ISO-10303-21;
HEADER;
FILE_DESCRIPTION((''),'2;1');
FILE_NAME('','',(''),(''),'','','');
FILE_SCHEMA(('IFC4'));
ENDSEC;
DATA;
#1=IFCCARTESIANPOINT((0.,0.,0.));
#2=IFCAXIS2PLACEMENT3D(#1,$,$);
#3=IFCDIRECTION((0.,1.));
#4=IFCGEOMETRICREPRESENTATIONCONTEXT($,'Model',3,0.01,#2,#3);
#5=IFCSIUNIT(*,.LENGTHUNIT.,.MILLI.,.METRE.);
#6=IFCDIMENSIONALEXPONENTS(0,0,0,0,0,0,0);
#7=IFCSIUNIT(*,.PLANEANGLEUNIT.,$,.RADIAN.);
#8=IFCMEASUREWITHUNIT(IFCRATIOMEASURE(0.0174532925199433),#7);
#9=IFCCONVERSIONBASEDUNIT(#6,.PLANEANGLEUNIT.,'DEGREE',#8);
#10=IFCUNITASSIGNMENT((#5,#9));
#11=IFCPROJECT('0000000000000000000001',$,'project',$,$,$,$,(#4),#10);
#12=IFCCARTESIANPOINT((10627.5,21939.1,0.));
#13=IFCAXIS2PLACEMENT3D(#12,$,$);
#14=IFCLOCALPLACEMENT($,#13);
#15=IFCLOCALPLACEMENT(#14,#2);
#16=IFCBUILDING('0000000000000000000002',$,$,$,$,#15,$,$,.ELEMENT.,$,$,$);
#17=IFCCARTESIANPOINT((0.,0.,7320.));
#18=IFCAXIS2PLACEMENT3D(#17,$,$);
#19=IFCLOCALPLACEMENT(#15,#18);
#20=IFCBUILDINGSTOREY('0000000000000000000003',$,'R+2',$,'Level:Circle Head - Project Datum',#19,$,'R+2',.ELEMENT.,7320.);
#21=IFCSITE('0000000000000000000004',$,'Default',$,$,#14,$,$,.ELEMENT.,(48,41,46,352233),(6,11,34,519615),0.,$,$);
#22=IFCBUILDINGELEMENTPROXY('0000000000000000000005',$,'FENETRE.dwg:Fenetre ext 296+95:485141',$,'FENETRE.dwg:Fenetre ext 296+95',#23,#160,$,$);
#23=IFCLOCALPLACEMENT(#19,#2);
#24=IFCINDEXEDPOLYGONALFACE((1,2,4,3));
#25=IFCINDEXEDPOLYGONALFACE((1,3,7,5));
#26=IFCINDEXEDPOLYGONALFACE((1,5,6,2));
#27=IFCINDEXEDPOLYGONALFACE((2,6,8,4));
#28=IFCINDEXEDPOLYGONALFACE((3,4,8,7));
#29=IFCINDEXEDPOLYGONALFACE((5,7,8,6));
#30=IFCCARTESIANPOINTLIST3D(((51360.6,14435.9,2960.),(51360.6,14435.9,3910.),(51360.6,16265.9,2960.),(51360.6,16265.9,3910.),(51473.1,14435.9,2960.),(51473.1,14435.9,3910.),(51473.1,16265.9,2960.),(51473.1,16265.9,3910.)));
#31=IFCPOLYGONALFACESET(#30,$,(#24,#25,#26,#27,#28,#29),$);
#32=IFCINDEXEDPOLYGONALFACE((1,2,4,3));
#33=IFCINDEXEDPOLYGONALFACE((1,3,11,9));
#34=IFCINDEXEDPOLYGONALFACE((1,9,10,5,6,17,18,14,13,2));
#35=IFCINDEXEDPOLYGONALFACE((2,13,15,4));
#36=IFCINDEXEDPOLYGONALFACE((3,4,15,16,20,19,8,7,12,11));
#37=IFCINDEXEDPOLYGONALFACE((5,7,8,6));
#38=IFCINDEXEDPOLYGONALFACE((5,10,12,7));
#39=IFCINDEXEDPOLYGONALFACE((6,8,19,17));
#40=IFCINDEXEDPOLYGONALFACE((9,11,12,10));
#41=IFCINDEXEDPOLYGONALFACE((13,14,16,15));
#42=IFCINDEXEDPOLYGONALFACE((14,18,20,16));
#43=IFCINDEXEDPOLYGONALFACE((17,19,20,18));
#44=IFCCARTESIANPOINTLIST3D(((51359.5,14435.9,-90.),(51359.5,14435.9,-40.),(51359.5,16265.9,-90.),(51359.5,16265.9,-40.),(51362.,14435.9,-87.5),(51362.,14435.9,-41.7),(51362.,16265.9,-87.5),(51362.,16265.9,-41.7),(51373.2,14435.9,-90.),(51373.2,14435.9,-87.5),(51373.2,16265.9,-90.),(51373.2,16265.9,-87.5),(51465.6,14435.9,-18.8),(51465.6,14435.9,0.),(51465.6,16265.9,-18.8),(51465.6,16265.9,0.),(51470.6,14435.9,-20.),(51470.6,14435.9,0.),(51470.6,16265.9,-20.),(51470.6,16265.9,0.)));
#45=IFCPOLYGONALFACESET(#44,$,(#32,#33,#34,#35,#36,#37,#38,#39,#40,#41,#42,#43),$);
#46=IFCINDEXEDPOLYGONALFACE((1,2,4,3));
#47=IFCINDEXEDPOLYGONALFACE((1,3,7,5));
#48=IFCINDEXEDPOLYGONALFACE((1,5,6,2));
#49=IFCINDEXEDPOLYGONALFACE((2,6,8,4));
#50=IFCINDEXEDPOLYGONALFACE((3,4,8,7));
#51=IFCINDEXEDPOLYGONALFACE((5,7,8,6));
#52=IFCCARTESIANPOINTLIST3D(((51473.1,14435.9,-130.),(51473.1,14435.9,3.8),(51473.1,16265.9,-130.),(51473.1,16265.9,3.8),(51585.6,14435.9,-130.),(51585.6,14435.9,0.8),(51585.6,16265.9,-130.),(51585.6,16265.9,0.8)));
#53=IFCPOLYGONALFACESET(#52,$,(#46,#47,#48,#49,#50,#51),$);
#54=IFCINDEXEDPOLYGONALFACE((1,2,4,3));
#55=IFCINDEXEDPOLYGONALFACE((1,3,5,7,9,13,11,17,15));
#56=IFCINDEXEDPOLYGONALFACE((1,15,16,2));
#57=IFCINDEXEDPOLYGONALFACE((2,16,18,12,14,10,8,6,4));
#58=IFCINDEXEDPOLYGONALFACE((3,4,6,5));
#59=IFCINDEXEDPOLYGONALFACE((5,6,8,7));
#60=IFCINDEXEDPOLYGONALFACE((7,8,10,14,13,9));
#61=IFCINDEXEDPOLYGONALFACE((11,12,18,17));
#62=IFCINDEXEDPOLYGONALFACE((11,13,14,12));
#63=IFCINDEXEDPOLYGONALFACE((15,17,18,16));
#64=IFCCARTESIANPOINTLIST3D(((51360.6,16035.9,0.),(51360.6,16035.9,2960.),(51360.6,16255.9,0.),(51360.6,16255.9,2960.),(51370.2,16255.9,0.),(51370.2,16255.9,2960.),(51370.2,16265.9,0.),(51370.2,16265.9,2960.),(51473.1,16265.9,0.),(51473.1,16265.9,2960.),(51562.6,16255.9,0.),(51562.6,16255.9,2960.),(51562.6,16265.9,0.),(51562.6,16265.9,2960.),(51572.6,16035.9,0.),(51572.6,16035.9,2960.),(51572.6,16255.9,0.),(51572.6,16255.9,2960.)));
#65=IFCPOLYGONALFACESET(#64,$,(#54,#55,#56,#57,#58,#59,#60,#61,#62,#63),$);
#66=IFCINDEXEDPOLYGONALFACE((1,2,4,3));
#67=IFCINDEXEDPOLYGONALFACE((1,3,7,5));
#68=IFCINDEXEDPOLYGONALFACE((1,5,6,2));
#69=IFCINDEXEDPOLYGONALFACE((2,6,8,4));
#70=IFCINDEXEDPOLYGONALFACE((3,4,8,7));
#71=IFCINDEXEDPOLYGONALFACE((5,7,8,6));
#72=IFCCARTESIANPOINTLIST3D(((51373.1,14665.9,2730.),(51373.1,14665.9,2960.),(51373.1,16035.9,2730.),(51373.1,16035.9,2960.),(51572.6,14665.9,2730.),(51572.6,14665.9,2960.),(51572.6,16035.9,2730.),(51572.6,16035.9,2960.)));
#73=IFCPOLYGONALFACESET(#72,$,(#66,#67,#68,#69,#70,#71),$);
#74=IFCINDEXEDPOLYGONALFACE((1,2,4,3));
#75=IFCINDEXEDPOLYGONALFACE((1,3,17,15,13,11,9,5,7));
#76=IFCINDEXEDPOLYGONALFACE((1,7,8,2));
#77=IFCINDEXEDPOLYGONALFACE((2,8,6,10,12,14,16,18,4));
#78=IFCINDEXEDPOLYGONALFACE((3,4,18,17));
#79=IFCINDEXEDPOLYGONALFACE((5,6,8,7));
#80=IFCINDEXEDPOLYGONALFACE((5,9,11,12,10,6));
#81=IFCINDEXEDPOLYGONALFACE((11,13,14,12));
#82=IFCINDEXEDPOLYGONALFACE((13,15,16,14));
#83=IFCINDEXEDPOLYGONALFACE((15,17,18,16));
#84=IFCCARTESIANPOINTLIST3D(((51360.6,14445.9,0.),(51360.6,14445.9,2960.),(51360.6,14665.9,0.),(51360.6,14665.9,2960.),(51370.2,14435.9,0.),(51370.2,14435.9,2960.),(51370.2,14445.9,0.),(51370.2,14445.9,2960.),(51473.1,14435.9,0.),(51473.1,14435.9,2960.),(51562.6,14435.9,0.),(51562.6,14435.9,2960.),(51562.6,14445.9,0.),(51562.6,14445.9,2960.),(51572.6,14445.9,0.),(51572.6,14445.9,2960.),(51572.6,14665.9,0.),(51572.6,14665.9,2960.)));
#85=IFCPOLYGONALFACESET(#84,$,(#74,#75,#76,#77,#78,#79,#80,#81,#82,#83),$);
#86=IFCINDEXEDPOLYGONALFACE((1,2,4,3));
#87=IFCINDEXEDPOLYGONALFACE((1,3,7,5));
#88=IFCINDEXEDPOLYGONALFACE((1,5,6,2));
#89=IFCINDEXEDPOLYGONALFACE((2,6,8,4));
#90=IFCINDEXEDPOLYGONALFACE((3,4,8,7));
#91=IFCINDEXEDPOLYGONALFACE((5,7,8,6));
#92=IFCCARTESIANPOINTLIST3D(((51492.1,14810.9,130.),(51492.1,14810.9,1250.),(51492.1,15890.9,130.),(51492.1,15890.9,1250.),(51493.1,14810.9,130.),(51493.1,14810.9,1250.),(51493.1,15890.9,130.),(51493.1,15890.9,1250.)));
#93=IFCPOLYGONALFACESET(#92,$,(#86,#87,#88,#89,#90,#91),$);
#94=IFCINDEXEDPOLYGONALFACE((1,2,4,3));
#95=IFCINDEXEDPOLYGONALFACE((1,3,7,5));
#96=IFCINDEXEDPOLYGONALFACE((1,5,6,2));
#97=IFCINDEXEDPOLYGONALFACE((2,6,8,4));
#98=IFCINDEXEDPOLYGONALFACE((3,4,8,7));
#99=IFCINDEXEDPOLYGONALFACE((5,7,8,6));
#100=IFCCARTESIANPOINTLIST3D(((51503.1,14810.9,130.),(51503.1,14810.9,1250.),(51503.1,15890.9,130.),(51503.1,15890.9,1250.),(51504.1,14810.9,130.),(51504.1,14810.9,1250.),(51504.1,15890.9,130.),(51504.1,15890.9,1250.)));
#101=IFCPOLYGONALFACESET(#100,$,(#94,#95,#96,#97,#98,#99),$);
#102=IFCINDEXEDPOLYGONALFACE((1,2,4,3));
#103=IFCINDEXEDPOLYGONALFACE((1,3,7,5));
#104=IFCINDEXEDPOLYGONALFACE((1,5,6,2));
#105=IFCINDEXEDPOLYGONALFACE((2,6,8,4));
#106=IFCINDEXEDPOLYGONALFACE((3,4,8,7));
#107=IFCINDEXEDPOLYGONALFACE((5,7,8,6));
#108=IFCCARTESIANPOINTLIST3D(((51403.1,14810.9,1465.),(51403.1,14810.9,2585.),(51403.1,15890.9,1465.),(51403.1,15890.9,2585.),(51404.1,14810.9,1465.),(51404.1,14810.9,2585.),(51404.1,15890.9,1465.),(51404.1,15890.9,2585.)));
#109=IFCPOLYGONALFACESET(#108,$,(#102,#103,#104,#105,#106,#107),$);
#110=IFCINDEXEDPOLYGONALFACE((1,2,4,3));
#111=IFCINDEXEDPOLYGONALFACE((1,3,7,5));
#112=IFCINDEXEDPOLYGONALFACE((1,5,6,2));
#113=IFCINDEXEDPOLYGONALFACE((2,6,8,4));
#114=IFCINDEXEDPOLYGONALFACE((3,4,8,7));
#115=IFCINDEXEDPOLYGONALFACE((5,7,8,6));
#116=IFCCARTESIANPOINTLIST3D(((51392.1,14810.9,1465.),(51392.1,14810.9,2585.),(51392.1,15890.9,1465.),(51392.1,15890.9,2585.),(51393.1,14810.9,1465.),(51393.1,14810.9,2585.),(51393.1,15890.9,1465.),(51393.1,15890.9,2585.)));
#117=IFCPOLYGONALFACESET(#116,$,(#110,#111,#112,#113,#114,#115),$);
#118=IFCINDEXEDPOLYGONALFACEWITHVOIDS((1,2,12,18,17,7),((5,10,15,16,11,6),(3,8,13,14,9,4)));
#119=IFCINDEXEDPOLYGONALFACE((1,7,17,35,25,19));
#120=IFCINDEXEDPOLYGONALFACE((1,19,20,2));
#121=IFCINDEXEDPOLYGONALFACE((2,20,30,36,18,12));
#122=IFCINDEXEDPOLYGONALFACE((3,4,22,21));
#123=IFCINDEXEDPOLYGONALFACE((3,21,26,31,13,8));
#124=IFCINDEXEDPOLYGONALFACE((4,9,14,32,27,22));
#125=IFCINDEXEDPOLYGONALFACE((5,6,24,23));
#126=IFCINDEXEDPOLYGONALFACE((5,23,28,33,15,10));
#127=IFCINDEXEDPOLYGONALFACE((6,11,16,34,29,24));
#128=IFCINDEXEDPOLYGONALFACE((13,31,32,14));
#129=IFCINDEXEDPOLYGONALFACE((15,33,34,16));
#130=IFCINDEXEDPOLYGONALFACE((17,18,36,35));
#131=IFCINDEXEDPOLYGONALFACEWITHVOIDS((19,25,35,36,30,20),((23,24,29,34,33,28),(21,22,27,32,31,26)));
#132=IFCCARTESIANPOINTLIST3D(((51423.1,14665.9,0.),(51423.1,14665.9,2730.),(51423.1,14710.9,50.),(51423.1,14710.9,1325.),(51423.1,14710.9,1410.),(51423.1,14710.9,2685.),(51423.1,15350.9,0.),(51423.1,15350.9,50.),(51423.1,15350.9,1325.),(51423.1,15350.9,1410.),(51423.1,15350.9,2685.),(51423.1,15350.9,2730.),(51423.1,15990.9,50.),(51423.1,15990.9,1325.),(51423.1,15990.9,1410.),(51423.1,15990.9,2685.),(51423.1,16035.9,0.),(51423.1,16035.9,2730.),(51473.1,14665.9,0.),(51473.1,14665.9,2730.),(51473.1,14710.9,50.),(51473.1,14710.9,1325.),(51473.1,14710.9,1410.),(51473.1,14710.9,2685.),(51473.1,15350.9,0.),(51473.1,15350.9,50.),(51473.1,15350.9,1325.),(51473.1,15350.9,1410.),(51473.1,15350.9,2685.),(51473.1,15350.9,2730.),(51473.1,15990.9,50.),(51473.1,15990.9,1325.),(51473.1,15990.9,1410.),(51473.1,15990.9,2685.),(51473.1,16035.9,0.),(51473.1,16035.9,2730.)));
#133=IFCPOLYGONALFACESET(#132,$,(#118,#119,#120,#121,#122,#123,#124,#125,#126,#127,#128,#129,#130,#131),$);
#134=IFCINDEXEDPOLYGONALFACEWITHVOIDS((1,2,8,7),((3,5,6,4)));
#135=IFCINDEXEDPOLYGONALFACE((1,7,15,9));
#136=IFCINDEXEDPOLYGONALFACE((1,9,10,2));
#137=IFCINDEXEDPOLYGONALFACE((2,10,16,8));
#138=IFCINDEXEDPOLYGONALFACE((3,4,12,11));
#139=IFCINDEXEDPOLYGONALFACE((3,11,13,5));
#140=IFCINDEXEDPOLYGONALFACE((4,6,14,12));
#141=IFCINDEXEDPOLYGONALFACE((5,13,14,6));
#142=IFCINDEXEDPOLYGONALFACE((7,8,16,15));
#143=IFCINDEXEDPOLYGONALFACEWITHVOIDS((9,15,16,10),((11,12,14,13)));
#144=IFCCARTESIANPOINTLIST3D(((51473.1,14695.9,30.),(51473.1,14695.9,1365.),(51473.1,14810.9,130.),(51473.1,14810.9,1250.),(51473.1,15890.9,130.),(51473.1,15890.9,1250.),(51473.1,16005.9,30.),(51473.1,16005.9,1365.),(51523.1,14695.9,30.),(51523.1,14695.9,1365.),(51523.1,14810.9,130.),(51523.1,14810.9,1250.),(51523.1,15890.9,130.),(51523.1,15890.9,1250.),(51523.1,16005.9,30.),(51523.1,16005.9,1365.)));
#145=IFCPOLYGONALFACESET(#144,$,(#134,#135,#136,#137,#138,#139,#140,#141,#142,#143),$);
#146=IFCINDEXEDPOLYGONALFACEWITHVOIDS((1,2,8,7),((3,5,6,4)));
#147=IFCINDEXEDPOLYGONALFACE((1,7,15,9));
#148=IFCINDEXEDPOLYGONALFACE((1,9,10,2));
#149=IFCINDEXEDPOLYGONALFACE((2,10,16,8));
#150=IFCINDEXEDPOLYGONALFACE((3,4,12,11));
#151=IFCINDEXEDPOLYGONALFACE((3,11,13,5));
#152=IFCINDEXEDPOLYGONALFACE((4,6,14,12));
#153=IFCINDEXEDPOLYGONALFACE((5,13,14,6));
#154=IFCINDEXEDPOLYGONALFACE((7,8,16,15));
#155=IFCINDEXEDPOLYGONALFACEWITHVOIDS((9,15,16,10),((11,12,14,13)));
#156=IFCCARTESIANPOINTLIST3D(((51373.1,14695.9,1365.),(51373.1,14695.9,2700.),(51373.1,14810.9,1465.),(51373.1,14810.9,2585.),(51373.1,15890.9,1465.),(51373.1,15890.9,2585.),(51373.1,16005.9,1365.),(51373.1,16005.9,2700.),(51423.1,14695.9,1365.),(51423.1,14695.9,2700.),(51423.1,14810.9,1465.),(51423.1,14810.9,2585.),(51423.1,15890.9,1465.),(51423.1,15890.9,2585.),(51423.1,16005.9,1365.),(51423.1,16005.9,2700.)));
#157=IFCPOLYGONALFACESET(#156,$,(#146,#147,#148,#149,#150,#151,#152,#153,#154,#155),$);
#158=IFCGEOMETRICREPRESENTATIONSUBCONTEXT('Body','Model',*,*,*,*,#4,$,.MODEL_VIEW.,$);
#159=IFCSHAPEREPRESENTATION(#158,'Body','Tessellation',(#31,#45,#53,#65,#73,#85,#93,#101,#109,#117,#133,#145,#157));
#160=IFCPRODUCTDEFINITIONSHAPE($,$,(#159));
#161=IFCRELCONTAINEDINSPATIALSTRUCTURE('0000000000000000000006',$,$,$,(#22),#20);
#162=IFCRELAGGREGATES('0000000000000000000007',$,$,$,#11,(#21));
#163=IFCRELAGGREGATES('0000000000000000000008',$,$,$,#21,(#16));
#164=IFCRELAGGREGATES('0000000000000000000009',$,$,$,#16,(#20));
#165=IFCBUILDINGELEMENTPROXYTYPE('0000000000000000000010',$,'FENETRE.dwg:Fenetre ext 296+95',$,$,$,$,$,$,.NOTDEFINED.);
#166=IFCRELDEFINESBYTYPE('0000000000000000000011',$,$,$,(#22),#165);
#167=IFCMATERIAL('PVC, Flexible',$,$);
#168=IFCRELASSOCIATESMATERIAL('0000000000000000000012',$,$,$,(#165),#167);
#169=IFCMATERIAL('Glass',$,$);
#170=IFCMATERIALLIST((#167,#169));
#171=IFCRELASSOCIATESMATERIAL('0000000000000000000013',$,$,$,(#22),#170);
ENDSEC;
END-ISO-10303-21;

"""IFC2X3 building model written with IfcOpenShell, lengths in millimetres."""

from ifc_helpers import new_model, entity, si_unit, converted_unit, direction, frame, frame_2d, origin, origin_2d_with_axis, place, context, subcontext, project, spatial, polyline, rectangle, outline, extrude, source, transform, mapped, material, material_list, type_object, type_shapes, element, save


model = new_model("IFC2X3")

# Units and contexts
model_context = context("Model", 3, precision=0.01, world=origin(), true_north=direction((0.0, 1.0)))
body_context = subcontext(model_context, "Body", "Model", "MODEL_VIEW")
ifc_project = project(units=[si_unit("LENGTHUNIT", "METRE", prefix="MILLI"), converted_unit("PLANEANGLEUNIT", "DEGREE", entity("IfcRatioMeasure", 0.0174532925199433), si_unit("PLANEANGLEUNIT", "RADIAN"), dimensions=[0, 0, 0, 0, 0, 0, 0])], contexts=[model_context])

# Site, building, storey
site_placement = place(None, frame((10627.5, 21939.1, 0.0)))
site = spatial("IfcSite", under=ifc_project, at=site_placement, Name="Default", CompositionType="ELEMENT", RefLatitude=(48, 41, 46, 352233), RefLongitude=(6, 11, 34, 519615), RefElevation=0.0)
building_placement = place(site_placement, origin())
building = spatial("IfcBuilding", under=site, at=building_placement, CompositionType="ELEMENT")
storey_placement = place(building_placement, frame((0.0, 0.0, 7320.0)))
storey = spatial("IfcBuildingStorey", under=building, at=storey_placement, Name="R+2", ObjectType="Level:Circle Head - Project Datum", LongName="R+2", CompositionType="ELEMENT", Elevation=7320.0)

# Building element proxy
ifc_material_1 = material(Name="PVC, Flexible")
ifc_material_2 = material(Name="Glass")
ifc_material_list_1 = material_list([ifc_material_1, ifc_material_2])
building_element_proxy_type_1 = type_object("IfcBuildingElementProxyType", Name="FENETRE.dwg:Fenetre ext 296+95", PredefinedType="NOTDEFINED", material=ifc_material_1)
shared_shape_1 = source(origin(), body_context, "Body", "SweptSolid", [
    extrude(rectangle(XDim=1830.0, YDim=112.5, at=origin_2d_with_axis()), frame((-10.4, 56.3, 2960.0), z_axis=(0.0, 0.0, 1.0), x_axis=(-1.0, 0.0, 0.0)), (0.0, 0.0, 1.0), 950.0),
    extrude(outline(polyline([(-68.6, -14.4), (-72.5, -34.0), (-67.6, -35.0), (-63.9, -16.6), (44.3, -16.6), (54.1, 32.5), (40.6, 35.2), (40.1, 32.7), (51.2, 30.5), (42.2, -14.4), (-68.6, -14.4)])), frame((-925.4, 66.9, -47.5), z_axis=(-1.0, 0.0, 0.0), x_axis=(0.0, 0.980599, -0.196027)), (0.0, 0.0, -1.0), 1830.0),
    extrude(outline(polyline([(-64.7, -56.3), (66.2, -56.3), (66.2, 56.3), (-67.7, 56.3), (-64.7, -56.3)])), frame((-925.4, -56.3, -63.8), z_axis=(1.0, 0.0, 0.0), x_axis=(0.0, 0.0, -1.0)), (0.0, 0.0, 1.0), 1830.0),
    extrude(outline(polyline([(-55.6, 97.0), (-55.6, -5.9), (-55.6, -95.4), (-45.6, -95.4), (-45.6, -105.4), (174.4, -105.4), (174.4, 106.6), (-45.6, 106.6), (-45.6, 97.0), (-55.6, 97.0)])), frame((849.0, 5.9, 0.0), z_axis=(0.0, 0.0, -1.0), x_axis=(-1.0, 0.0, 0.0)), (0.0, 0.0, -1.0), 2960.0),
    extrude(rectangle(XDim=199.5, YDim=1370.0, at=origin_2d_with_axis()), frame((-10.4, 0.3, 2730.0), z_axis=(0.0, 0.0, 1.0), x_axis=(0.0, 1.0, 0.0)), (0.0, 0.0, 1.0), 230.0),
    extrude(outline(polyline([(-97.0, -55.6), (5.9, -55.6), (95.4, -55.6), (95.4, -45.6), (105.4, -45.6), (105.4, 174.4), (-106.6, 174.4), (-106.6, -45.6), (-97.0, -45.6), (-97.0, -55.6)])), frame((-869.9, 5.9, 0.0), z_axis=(0.0, 0.0, 1.0), x_axis=(0.0, -1.0, 0.0)), (0.0, 0.0, 1.0), 2960.0),
    extrude(rectangle(XDim=1.0, YDim=1080.0, at=origin_2d_with_axis()), frame((-10.4, -19.5, 130.0), z_axis=(0.0, 0.0, 1.0), x_axis=(0.0, 1.0, 0.0)), (0.0, 0.0, 1.0), 1120.0),
    extrude(rectangle(XDim=1.0, YDim=1080.0, at=frame_2d((0.0, 0.0), x_axis=(1.0, 0.0))), frame((-10.4, -30.5, 130.0), z_axis=(0.0, 0.0, 1.0), x_axis=(0.0, 1.0, 0.0)), (0.0, 0.0, 1.0), 1120.0),
    extrude(rectangle(XDim=1.0, YDim=1080.0, at=frame_2d((0.0, 0.0), x_axis=(1.0, 0.0))), frame((-10.4, 69.5, 1465.0), z_axis=(0.0, 0.0, 1.0), x_axis=(0.0, 1.0, 0.0)), (0.0, 0.0, 1.0), 1120.0),
    extrude(rectangle(XDim=1.0, YDim=1080.0, at=frame_2d((0.0, 0.0), x_axis=(1.0, 0.0))), frame((-10.4, 80.5, 1465.0), z_axis=(0.0, 0.0, 1.0), x_axis=(0.0, 1.0, 0.0)), (0.0, 0.0, 1.0), 1120.0),
    extrude(outline(polyline([(-685.0, -1365.0), (0.0, -1365.0), (685.0, -1365.0), (685.0, 1365.0), (0.0, 1365.0), (-685.0, 1365.0), (-685.0, -1365.0)]), holes=[polyline([(-640.0, -1320.0), (-640.0, -45.0), (0.0, -45.0), (640.0, -45.0), (640.0, -1320.0), (0.0, -1320.0), (-640.0, -1320.0)]), polyline([(-640.0, 40.0), (-640.0, 1315.0), (0.0, 1315.0), (640.0, 1315.0), (640.0, 40.0), (0.0, 40.0), (-640.0, 40.0)])]), frame((-10.4, 0.0, 1365.0), z_axis=(0.0, 1.0, 0.0), x_axis=(1.0, 0.0, 0.0)), (0.0, 0.0, 1.0), 50.0),
    extrude(outline(polyline([(-655.0, -667.5), (655.0, -667.5), (655.0, 667.5), (-655.0, 667.5), (-655.0, -667.5)]), holes=[polyline([(-540.0, 552.5), (540.0, 552.5), (540.0, -567.5), (-540.0, -567.5), (-540.0, 552.5)])]), frame((-10.4, -50.0, 697.5), z_axis=(0.0, 1.0, 0.0), x_axis=(-1.0, 0.0, 0.0)), (0.0, 0.0, 1.0), 50.0),
    extrude(outline(polyline([(-655.0, -667.5), (655.0, -667.5), (655.0, 667.5), (-655.0, 667.5), (-655.0, -667.5)]), holes=[polyline([(-540.0, 552.5), (540.0, 552.5), (540.0, -567.5), (-540.0, -567.5), (-540.0, 552.5)])]), frame((-10.4, 50.0, 2032.5), z_axis=(0.0, 1.0, 0.0), x_axis=(-1.0, 0.0, 0.0)), (0.0, 0.0, 1.0), 50.0),
])
type_shapes(building_element_proxy_type_1, [shared_shape_1])
proxy_1_placement = place(storey_placement, frame((51473.1, 15361.3, 0.0), z_axis=(0.0, 0.0, 1.0), x_axis=(0.0, 1.0, 0.0)))
element("IfcBuildingElementProxy", 1, at=proxy_1_placement, inside=storey, type_object=building_element_proxy_type_1, material=ifc_material_list_1, Name="FENETRE.dwg:Fenetre ext 296+95:485141", ObjectType="FENETRE.dwg:Fenetre ext 296+95", context=body_context, shape_type="MappedRepresentation", body=[
    mapped(shared_shape_1, transform((0.0, 0.0, 0.0), scale=1.0)),
])

save(model, "model.ifc")
